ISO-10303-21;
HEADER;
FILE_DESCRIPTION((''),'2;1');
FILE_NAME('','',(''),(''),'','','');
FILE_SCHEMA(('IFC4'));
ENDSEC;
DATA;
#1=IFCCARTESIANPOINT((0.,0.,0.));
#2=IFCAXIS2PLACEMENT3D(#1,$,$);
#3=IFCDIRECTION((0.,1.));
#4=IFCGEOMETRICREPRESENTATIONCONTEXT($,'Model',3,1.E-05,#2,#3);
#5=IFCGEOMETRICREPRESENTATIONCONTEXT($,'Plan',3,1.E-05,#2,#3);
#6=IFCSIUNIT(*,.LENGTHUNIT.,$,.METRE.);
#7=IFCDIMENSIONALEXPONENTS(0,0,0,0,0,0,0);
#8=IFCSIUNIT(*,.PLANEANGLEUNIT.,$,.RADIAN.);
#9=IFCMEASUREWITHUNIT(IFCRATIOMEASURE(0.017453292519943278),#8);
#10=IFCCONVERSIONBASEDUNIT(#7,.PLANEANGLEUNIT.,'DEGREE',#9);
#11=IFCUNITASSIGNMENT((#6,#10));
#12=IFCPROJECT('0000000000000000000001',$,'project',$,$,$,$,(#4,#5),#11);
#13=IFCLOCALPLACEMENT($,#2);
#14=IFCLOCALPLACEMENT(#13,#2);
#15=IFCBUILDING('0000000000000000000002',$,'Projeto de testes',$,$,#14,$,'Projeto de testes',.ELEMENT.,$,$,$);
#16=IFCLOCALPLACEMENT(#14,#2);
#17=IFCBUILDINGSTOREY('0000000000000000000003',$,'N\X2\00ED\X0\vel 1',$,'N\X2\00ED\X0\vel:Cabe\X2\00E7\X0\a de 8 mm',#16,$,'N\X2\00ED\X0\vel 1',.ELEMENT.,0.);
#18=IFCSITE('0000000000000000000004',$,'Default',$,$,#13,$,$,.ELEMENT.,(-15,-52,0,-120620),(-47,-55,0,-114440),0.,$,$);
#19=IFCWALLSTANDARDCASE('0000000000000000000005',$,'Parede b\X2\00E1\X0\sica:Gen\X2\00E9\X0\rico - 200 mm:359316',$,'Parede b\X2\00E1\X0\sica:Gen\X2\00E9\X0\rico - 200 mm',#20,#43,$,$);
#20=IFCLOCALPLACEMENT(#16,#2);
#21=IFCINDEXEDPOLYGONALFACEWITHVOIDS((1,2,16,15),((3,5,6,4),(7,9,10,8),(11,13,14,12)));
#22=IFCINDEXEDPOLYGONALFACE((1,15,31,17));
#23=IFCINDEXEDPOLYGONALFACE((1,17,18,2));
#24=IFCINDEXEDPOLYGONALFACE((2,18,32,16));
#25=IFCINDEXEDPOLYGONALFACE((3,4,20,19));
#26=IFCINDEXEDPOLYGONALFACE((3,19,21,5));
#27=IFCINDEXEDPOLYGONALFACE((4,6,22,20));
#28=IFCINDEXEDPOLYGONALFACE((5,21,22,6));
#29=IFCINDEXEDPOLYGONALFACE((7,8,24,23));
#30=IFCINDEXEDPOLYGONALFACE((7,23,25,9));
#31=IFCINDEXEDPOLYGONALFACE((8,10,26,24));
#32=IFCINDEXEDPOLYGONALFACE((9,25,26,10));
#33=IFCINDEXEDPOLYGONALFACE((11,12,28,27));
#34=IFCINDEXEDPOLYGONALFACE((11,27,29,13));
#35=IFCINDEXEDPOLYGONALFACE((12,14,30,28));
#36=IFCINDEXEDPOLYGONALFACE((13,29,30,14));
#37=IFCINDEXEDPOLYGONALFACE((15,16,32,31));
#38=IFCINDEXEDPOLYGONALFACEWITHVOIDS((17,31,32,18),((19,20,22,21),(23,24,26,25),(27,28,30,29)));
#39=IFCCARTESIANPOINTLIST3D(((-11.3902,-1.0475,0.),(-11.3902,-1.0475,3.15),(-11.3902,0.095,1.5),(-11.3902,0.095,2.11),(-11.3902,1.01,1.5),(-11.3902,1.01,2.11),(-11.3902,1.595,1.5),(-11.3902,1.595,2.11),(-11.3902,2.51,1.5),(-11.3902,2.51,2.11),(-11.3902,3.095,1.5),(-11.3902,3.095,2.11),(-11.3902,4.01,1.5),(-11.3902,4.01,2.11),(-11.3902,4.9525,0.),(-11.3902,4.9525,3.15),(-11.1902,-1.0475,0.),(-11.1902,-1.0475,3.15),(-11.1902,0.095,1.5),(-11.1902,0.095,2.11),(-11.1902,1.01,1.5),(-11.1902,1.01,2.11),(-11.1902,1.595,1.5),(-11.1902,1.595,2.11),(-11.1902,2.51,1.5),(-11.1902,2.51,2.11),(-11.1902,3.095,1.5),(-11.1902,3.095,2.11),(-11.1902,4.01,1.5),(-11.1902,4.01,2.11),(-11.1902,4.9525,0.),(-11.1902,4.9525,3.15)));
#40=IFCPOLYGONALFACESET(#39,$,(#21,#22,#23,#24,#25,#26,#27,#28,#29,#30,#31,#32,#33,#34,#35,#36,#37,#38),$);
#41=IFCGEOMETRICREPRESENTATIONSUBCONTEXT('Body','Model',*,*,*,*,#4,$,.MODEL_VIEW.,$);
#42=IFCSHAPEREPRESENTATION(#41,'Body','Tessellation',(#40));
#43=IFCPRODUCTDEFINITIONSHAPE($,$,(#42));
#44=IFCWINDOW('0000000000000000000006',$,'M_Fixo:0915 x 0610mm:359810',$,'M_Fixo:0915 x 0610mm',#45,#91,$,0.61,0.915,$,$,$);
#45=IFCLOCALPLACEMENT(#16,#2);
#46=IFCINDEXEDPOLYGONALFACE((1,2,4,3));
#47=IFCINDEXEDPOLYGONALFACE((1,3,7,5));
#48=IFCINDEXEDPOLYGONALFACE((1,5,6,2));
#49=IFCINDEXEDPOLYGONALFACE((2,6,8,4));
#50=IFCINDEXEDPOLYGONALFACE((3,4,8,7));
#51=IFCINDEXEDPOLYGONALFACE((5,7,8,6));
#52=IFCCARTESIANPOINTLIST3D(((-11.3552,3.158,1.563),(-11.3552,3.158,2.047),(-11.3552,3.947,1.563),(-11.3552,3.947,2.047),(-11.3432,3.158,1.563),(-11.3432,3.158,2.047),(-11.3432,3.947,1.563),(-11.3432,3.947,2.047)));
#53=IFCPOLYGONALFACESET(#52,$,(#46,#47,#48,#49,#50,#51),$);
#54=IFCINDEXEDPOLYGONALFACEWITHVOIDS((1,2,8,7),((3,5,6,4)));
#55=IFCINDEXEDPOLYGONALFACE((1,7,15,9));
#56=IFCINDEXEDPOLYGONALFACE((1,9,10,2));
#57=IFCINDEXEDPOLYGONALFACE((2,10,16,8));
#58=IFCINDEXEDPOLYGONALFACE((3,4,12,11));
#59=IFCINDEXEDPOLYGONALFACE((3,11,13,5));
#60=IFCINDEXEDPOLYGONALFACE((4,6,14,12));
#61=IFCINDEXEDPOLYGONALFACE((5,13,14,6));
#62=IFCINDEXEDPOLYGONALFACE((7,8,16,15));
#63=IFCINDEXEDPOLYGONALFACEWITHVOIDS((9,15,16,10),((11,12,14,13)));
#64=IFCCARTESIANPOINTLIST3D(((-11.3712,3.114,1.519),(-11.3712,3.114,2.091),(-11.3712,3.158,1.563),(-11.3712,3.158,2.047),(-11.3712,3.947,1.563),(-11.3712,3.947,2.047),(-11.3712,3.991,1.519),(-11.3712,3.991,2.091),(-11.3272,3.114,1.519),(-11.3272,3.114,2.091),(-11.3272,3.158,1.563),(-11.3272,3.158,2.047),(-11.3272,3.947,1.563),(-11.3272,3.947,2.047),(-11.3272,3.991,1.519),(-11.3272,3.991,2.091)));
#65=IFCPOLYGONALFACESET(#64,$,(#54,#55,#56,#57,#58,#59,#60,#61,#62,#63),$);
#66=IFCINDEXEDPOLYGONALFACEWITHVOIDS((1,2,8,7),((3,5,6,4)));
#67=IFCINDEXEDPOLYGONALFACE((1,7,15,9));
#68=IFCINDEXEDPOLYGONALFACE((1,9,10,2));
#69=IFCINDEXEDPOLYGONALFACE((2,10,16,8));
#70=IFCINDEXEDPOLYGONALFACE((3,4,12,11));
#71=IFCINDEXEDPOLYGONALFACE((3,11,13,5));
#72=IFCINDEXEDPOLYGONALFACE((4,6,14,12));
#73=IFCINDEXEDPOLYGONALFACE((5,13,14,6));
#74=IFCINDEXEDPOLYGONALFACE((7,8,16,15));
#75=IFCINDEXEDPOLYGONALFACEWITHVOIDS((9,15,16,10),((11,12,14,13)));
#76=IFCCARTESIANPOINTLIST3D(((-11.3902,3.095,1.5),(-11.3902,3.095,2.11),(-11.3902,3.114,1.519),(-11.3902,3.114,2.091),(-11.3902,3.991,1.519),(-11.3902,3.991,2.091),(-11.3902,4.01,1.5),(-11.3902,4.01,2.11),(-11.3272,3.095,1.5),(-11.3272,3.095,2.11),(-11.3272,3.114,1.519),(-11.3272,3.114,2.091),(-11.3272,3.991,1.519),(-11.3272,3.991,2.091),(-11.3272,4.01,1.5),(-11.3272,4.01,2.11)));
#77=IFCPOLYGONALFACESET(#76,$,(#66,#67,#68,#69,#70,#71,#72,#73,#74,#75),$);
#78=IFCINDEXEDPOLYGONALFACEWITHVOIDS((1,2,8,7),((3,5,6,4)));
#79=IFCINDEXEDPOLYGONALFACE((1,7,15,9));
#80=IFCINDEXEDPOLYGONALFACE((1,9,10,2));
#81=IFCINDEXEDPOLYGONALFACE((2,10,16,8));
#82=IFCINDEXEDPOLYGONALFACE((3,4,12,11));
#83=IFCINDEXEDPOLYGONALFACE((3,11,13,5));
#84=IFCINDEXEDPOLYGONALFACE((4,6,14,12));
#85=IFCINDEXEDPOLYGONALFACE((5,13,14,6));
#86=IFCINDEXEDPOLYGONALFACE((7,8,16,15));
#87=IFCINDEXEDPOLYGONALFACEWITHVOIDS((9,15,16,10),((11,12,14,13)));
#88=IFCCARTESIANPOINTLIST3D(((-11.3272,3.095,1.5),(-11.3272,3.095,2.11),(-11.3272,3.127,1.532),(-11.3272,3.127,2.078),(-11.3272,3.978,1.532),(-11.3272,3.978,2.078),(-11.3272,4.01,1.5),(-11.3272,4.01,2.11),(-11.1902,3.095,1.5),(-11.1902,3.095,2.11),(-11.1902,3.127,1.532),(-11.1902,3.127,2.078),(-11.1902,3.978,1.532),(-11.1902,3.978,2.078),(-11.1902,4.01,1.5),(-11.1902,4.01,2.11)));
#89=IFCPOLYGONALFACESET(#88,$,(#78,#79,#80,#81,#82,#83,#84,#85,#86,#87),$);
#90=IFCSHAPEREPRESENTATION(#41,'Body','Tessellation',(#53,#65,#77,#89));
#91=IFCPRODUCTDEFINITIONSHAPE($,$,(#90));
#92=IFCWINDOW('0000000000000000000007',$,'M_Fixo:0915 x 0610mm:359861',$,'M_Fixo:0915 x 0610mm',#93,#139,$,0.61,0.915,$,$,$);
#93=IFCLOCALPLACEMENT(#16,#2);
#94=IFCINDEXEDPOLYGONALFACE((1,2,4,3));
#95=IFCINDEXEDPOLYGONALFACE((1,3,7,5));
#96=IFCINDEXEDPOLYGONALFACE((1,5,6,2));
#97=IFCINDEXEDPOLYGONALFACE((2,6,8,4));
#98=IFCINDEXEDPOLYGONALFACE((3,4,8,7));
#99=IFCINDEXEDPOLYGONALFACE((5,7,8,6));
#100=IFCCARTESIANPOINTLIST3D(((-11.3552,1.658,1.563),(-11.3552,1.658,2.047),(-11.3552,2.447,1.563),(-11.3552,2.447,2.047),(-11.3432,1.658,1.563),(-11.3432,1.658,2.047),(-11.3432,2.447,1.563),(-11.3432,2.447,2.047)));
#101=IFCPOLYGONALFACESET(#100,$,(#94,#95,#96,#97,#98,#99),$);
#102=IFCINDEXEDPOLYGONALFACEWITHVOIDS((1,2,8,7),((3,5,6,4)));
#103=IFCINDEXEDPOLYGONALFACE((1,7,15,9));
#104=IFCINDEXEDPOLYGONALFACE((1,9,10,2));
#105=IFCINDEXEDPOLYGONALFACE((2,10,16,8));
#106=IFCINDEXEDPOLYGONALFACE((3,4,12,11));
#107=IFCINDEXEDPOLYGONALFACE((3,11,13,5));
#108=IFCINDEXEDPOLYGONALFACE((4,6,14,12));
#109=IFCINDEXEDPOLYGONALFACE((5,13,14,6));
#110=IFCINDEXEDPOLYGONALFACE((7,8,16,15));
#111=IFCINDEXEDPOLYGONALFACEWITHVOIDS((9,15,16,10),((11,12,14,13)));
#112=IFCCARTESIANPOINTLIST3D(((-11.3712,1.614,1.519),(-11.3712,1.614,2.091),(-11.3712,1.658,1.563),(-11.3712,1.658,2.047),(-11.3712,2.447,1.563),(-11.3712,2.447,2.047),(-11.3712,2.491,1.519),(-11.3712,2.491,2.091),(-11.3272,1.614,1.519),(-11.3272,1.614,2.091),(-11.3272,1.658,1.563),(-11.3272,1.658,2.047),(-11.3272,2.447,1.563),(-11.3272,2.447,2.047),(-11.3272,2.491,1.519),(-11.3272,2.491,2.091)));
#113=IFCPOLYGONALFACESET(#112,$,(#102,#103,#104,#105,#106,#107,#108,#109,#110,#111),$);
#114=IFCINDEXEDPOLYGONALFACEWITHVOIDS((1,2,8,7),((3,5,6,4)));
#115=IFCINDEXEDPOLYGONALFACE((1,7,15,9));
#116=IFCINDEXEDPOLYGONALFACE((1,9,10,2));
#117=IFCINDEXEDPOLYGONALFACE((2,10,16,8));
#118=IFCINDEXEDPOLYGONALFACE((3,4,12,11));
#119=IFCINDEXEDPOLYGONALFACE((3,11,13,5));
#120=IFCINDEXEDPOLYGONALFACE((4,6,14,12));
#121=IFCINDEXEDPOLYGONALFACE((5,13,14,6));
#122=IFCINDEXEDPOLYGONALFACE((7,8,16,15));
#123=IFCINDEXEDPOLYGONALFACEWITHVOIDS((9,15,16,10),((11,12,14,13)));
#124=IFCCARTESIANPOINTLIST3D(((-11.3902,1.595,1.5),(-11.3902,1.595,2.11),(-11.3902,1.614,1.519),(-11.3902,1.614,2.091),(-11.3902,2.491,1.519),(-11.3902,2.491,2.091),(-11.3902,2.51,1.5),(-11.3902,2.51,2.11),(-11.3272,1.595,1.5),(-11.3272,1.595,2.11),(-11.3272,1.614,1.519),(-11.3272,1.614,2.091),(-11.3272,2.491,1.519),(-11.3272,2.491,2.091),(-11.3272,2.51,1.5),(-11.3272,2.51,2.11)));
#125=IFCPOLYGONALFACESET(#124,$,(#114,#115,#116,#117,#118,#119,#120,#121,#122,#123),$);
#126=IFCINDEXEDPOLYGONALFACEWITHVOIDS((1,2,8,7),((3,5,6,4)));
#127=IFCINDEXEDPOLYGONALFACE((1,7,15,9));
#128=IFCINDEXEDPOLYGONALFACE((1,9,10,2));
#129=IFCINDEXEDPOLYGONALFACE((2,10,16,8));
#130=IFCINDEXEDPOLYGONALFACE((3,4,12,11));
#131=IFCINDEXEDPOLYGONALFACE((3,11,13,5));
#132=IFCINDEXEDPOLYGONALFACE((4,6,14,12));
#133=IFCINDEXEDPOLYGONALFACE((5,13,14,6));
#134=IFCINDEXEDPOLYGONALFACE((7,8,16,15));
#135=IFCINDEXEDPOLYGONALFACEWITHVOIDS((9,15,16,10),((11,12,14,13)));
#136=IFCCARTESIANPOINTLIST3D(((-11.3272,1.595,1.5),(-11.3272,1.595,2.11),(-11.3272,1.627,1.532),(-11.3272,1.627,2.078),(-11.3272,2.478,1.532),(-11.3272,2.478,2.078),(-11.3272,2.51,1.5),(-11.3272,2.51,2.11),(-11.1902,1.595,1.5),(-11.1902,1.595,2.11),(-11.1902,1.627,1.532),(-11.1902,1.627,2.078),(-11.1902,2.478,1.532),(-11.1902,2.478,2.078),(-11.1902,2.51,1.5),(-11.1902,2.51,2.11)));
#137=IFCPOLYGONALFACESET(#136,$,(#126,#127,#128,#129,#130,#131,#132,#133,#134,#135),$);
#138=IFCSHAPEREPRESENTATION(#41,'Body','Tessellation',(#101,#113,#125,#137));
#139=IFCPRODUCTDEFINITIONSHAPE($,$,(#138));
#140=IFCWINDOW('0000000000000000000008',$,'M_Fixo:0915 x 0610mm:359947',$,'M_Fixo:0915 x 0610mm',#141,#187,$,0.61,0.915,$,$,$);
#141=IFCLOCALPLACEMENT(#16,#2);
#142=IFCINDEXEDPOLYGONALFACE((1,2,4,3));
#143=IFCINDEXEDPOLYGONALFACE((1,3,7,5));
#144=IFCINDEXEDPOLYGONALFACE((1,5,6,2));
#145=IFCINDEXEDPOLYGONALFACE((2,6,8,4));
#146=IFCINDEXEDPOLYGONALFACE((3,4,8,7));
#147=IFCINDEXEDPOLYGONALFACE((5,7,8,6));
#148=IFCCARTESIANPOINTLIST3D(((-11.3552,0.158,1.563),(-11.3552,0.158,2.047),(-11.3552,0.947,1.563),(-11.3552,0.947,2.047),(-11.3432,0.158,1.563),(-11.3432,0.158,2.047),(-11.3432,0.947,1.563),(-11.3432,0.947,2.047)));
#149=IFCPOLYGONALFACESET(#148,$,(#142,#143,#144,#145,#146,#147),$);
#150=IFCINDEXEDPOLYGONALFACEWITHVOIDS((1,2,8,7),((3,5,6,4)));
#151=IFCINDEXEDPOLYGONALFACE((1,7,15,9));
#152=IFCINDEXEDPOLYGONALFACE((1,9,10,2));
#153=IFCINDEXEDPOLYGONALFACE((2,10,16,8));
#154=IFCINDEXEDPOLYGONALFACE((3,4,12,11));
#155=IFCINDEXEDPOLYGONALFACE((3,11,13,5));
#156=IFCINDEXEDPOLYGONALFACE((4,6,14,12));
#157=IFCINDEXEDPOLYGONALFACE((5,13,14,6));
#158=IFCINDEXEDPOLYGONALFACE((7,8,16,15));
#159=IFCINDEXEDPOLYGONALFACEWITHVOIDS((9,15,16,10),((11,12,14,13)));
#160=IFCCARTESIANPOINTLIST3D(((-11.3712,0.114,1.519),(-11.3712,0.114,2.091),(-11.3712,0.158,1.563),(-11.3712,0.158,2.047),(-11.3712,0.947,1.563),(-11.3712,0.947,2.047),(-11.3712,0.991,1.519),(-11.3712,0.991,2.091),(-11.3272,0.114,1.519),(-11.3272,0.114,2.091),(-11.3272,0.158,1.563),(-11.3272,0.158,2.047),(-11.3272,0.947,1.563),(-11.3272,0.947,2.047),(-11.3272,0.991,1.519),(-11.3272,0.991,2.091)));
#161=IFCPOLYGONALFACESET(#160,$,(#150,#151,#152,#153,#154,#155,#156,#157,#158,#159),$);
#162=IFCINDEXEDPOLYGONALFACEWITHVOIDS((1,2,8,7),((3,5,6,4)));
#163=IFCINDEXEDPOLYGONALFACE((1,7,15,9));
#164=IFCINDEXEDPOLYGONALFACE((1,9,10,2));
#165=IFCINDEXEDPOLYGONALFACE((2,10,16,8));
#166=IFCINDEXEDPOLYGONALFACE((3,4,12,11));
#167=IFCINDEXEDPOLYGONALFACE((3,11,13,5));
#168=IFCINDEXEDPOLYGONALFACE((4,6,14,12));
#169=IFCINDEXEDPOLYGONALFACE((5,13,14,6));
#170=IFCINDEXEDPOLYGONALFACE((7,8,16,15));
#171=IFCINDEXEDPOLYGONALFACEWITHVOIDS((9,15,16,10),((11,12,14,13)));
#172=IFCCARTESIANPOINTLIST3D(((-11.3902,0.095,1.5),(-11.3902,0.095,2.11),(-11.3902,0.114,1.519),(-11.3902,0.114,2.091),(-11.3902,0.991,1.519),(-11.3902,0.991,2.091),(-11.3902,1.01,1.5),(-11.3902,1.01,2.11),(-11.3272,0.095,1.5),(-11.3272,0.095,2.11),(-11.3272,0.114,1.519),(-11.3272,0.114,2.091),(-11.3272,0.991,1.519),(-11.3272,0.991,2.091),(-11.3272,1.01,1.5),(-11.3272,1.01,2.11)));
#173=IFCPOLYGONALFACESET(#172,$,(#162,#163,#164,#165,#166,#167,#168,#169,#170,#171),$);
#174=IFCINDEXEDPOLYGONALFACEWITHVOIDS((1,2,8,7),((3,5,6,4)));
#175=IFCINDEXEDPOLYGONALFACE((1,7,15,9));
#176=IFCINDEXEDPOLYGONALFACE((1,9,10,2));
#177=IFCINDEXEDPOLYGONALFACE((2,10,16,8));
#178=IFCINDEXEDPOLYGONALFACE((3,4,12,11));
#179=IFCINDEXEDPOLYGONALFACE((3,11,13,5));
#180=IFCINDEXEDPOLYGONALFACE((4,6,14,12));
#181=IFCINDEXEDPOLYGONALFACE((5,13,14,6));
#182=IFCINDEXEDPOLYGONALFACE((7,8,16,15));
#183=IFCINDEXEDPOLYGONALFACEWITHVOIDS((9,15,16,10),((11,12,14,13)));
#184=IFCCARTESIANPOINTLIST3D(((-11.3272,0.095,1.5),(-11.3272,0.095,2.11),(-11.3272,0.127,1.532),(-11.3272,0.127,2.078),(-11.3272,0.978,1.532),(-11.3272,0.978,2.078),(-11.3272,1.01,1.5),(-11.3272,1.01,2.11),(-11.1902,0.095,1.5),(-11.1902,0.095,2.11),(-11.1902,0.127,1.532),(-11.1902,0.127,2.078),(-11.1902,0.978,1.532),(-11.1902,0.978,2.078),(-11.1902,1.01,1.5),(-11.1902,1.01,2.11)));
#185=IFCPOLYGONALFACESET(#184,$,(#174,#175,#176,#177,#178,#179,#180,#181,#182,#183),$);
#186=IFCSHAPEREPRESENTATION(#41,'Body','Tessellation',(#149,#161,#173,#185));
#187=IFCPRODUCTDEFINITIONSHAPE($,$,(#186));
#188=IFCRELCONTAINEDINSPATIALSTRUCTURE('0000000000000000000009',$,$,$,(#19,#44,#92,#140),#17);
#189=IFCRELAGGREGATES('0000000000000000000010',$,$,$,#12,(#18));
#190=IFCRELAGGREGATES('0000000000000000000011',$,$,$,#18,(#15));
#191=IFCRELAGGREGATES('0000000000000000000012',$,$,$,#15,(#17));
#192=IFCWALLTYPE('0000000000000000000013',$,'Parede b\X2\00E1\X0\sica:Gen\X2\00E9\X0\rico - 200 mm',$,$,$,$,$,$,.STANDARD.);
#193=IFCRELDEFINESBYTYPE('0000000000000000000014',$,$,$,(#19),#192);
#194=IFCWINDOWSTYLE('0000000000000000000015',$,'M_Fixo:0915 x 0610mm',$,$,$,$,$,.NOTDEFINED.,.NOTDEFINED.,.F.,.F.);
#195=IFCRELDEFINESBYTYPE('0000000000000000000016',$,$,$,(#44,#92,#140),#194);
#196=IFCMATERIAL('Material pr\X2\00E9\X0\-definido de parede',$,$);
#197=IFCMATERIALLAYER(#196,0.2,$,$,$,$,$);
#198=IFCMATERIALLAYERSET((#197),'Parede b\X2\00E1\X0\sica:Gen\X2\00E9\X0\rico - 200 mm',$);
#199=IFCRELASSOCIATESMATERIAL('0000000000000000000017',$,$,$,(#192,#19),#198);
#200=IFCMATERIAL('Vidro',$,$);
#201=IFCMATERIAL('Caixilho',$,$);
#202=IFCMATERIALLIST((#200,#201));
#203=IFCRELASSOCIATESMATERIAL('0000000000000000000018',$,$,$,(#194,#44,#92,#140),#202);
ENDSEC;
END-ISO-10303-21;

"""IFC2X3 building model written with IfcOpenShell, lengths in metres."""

from ifc_helpers import new_model, entity, si_unit, converted_unit, direction, frame, frame_2d, origin, place, context, subcontext, project, spatial, polyline, rectangle, outline, extrude, source, transform, mapped, material, material_list, layer, layer_set, layer_usage, type_object, type_shapes, element, fill, save


model = new_model("IFC2X3")

# Units and contexts
model_context = context("Model", 3, precision=1e-05, world=origin(), true_north=direction((0.0, 1.0)))
plan_context = context("Plan", 3, precision=1e-05, world=origin(), true_north=direction((0.0, 1.0)))
body_context = subcontext(model_context, "Body", "Model", "MODEL_VIEW")
ifc_project = project(units=[si_unit("LENGTHUNIT", "METRE"), converted_unit("PLANEANGLEUNIT", "DEGREE", entity("IfcRatioMeasure", 0.017453292519943278), si_unit("PLANEANGLEUNIT", "RADIAN"), dimensions=[0, 0, 0, 0, 0, 0, 0])], contexts=[model_context, plan_context])

# Site, building, storey
site_placement = place(None, origin())
site = spatial("IfcSite", under=ifc_project, at=site_placement, Name="Default", CompositionType="ELEMENT", RefLatitude=(-15, -52, 0, -120620), RefLongitude=(-47, -55, 0, -114440), RefElevation=0.0)
building_placement = place(site_placement, origin())
building = spatial("IfcBuilding", under=site, at=building_placement, Name="Projeto de testes", LongName="Projeto de testes", CompositionType="ELEMENT")
storey_placement = place(building_placement, origin())
storey = spatial("IfcBuildingStorey", under=building, at=storey_placement, Name="Nível 1", ObjectType="Nível:Cabeça de 8 mm", LongName="Nível 1", CompositionType="ELEMENT", Elevation=0.0)

# Shared definitions
ifc_material_1 = material(Name="Material pré-definido de parede")
ifc_layer_1 = layer(ifc_material_1, 0.2)
ifc_layer_set_1 = layer_set([ifc_layer_1], Name="Parede básica:Genérico - 200 mm")
wall_type = type_object("IfcWallType", Name="Parede básica:Genérico - 200 mm", PredefinedType="STANDARD", material=ifc_layer_set_1)

# Shared definitions
ifc_layer_usage_1 = layer_usage(ifc_layer_set_1, "AXIS2", "NEGATIVE", 0.1)

# Wall, openings, windows
wall_1_placement = place(storey_placement, frame((-11.2902, 4.9525, 0.0), z_axis=(0.0, 0.0, 1.0), x_axis=(0.0, -1.0, 0.0)))
wall_1 = element("IfcWallStandardCase", 1, at=wall_1_placement, inside=storey, type_object=wall_type, material=ifc_layer_usage_1, Name="Parede básica:Genérico - 200 mm:359316", ObjectType="Parede básica:Genérico - 200 mm", context=body_context, shape_type="SweptSolid", body=[
    extrude(rectangle(XDim=6.0, YDim=0.2, at=frame_2d((3.0, 0.0), x_axis=(-1.0, 0.0))), origin(), (0.0, 0.0, 1.0), 3.15),
])
opening_1_placement = place(wall_1_placement, frame((1.8575, 0.1, 1.5)))
opening_1 = element("IfcOpeningElement", 2, at=opening_1_placement, cuts=wall_1, ObjectType="Opening", context=body_context, shape_type="SweptSolid", body=[
    extrude(rectangle(XDim=0.61, YDim=0.915, at=frame_2d((0.305, 0.4575), x_axis=(1.0, 0.0))), frame((0.0, 0.0, 0.0), z_axis=(0.0, -1.0, 0.0), x_axis=(0.0, 0.0, 1.0)), (0.0, 0.0, 1.0), 0.2),
])
opening_2_placement = place(wall_1_placement, frame((3.3575, 0.1, 1.5)))
opening_2 = element("IfcOpeningElement", 3, at=opening_2_placement, cuts=wall_1, ObjectType="Opening", context=body_context, shape_type="SweptSolid", body=[
    extrude(rectangle(XDim=0.61, YDim=0.915, at=frame_2d((0.305, 0.4575), x_axis=(1.0, 0.0))), frame((0.0, 0.0, 0.0), z_axis=(0.0, -1.0, 0.0), x_axis=(0.0, 0.0, 1.0)), (0.0, 0.0, 1.0), 0.2),
])
opening_3_placement = place(wall_1_placement, frame((4.8575, 0.1, 1.5)))
opening_3 = element("IfcOpeningElement", 4, at=opening_3_placement, cuts=wall_1, ObjectType="Opening", context=body_context, shape_type="SweptSolid", body=[
    extrude(rectangle(XDim=0.61, YDim=0.915, at=frame_2d((0.305, 0.4575), x_axis=(1.0, 0.0))), frame((0.0, 0.0, 0.0), z_axis=(0.0, -1.0, 0.0), x_axis=(0.0, 0.0, 1.0)), (0.0, 0.0, 1.0), 0.2),
])
ifc_material_2 = material(Name="Vidro")
ifc_material_3 = material(Name="Caixilho")
ifc_material_list_1 = material_list([ifc_material_2, ifc_material_3])
window_style = type_object("IfcWindowStyle", Name="M_Fixo:0915 x 0610mm", ConstructionType="NOTDEFINED", OperationType="NOTDEFINED", ParameterTakesPrecedence=False, Sizeable=False, material=ifc_material_list_1)
shared_shape_1 = source(origin(), body_context, "Body", "SweptSolid", [
    extrude(rectangle(XDim=0.012, YDim=0.789, at=frame_2d((0.0, 0.0), x_axis=(1.0, 0.0))), frame((0.4575, 0.159, 0.063), z_axis=(0.0, 0.0, 1.0), x_axis=(0.0, -1.0, 0.0)), (0.0, 0.0, 1.0), 0.484),
    extrude(outline(polyline([(-0.4385, -0.286), (0.4385, -0.286), (0.4385, 0.286), (-0.4385, 0.286), (-0.4385, -0.286)]), holes=[polyline([(-0.3945, -0.242), (-0.3945, 0.242), (0.3945, 0.242), (0.3945, -0.242), (-0.3945, -0.242)])]), frame((0.4575, 0.137, 0.305), z_axis=(0.0, 1.0, 0.0), x_axis=(1.0, 0.0, 0.0)), (0.0, 0.0, 1.0), 0.044),
    extrude(outline(polyline([(-0.4575, -0.305), (0.4575, -0.305), (0.4575, 0.305), (-0.4575, 0.305), (-0.4575, -0.305)]), holes=[polyline([(-0.4385, -0.286), (-0.4385, 0.286), (0.4385, 0.286), (0.4385, -0.286), (-0.4385, -0.286)])]), frame((0.4575, 0.137, 0.305), z_axis=(0.0, 1.0, 0.0), x_axis=(1.0, 0.0, 0.0)), (0.0, 0.0, 1.0), 0.063),
    extrude(outline(polyline([(-0.4575, -0.305), (0.4575, -0.305), (0.4575, 0.305), (-0.4575, 0.305), (-0.4575, -0.305)]), holes=[polyline([(-0.4255, -0.273), (-0.4255, 0.273), (0.4255, 0.273), (0.4255, -0.273), (-0.4255, -0.273)])]), frame((0.4575, 0.0, 0.305), z_axis=(0.0, 1.0, 0.0), x_axis=(1.0, 0.0, 0.0)), (0.0, 0.0, 1.0), 0.137),
])
type_shapes(window_style, [shared_shape_1])
window_1_placement = place(opening_1_placement, frame((0.0, 0.0, 0.0), z_axis=(0.0, 0.0, 1.0), x_axis=(-1.0, 0.0, 0.0)))
window_1 = element("IfcWindow", 5, at=window_1_placement, inside=storey, type_object=window_style, material=ifc_material_list_1, Name="M_Fixo:0915 x 0610mm:359810", ObjectType="M_Fixo:0915 x 0610mm", OverallHeight=0.61, OverallWidth=0.915, context=body_context, shape_type="MappedRepresentation", body=[
    mapped(shared_shape_1, transform((0.0, 0.0, 0.0), scale=1.0)),
])
fill(opening_1, window_1)
window_2_placement = place(opening_2_placement, frame((0.0, 0.0, 0.0), z_axis=(0.0, 0.0, 1.0), x_axis=(-1.0, 0.0, 0.0)))
window_2 = element("IfcWindow", 6, at=window_2_placement, inside=storey, type_object=window_style, material=ifc_material_list_1, Name="M_Fixo:0915 x 0610mm:359861", ObjectType="M_Fixo:0915 x 0610mm", OverallHeight=0.61, OverallWidth=0.915, context=body_context, shape_type="MappedRepresentation", body=[
    mapped(shared_shape_1, transform((0.0, 0.0, 0.0), scale=1.0)),
])
fill(opening_2, window_2)
window_3_placement = place(opening_3_placement, frame((0.0, 0.0, 0.0), z_axis=(0.0, 0.0, 1.0), x_axis=(-1.0, 0.0, 0.0)))
window_3 = element("IfcWindow", 7, at=window_3_placement, inside=storey, type_object=window_style, material=ifc_material_list_1, Name="M_Fixo:0915 x 0610mm:359947", ObjectType="M_Fixo:0915 x 0610mm", OverallHeight=0.61, OverallWidth=0.915, context=body_context, shape_type="MappedRepresentation", body=[
    mapped(shared_shape_1, transform((0.0, 0.0, 0.0), scale=1.0)),
])
fill(opening_3, window_3)

save(model, "model.ifc")
